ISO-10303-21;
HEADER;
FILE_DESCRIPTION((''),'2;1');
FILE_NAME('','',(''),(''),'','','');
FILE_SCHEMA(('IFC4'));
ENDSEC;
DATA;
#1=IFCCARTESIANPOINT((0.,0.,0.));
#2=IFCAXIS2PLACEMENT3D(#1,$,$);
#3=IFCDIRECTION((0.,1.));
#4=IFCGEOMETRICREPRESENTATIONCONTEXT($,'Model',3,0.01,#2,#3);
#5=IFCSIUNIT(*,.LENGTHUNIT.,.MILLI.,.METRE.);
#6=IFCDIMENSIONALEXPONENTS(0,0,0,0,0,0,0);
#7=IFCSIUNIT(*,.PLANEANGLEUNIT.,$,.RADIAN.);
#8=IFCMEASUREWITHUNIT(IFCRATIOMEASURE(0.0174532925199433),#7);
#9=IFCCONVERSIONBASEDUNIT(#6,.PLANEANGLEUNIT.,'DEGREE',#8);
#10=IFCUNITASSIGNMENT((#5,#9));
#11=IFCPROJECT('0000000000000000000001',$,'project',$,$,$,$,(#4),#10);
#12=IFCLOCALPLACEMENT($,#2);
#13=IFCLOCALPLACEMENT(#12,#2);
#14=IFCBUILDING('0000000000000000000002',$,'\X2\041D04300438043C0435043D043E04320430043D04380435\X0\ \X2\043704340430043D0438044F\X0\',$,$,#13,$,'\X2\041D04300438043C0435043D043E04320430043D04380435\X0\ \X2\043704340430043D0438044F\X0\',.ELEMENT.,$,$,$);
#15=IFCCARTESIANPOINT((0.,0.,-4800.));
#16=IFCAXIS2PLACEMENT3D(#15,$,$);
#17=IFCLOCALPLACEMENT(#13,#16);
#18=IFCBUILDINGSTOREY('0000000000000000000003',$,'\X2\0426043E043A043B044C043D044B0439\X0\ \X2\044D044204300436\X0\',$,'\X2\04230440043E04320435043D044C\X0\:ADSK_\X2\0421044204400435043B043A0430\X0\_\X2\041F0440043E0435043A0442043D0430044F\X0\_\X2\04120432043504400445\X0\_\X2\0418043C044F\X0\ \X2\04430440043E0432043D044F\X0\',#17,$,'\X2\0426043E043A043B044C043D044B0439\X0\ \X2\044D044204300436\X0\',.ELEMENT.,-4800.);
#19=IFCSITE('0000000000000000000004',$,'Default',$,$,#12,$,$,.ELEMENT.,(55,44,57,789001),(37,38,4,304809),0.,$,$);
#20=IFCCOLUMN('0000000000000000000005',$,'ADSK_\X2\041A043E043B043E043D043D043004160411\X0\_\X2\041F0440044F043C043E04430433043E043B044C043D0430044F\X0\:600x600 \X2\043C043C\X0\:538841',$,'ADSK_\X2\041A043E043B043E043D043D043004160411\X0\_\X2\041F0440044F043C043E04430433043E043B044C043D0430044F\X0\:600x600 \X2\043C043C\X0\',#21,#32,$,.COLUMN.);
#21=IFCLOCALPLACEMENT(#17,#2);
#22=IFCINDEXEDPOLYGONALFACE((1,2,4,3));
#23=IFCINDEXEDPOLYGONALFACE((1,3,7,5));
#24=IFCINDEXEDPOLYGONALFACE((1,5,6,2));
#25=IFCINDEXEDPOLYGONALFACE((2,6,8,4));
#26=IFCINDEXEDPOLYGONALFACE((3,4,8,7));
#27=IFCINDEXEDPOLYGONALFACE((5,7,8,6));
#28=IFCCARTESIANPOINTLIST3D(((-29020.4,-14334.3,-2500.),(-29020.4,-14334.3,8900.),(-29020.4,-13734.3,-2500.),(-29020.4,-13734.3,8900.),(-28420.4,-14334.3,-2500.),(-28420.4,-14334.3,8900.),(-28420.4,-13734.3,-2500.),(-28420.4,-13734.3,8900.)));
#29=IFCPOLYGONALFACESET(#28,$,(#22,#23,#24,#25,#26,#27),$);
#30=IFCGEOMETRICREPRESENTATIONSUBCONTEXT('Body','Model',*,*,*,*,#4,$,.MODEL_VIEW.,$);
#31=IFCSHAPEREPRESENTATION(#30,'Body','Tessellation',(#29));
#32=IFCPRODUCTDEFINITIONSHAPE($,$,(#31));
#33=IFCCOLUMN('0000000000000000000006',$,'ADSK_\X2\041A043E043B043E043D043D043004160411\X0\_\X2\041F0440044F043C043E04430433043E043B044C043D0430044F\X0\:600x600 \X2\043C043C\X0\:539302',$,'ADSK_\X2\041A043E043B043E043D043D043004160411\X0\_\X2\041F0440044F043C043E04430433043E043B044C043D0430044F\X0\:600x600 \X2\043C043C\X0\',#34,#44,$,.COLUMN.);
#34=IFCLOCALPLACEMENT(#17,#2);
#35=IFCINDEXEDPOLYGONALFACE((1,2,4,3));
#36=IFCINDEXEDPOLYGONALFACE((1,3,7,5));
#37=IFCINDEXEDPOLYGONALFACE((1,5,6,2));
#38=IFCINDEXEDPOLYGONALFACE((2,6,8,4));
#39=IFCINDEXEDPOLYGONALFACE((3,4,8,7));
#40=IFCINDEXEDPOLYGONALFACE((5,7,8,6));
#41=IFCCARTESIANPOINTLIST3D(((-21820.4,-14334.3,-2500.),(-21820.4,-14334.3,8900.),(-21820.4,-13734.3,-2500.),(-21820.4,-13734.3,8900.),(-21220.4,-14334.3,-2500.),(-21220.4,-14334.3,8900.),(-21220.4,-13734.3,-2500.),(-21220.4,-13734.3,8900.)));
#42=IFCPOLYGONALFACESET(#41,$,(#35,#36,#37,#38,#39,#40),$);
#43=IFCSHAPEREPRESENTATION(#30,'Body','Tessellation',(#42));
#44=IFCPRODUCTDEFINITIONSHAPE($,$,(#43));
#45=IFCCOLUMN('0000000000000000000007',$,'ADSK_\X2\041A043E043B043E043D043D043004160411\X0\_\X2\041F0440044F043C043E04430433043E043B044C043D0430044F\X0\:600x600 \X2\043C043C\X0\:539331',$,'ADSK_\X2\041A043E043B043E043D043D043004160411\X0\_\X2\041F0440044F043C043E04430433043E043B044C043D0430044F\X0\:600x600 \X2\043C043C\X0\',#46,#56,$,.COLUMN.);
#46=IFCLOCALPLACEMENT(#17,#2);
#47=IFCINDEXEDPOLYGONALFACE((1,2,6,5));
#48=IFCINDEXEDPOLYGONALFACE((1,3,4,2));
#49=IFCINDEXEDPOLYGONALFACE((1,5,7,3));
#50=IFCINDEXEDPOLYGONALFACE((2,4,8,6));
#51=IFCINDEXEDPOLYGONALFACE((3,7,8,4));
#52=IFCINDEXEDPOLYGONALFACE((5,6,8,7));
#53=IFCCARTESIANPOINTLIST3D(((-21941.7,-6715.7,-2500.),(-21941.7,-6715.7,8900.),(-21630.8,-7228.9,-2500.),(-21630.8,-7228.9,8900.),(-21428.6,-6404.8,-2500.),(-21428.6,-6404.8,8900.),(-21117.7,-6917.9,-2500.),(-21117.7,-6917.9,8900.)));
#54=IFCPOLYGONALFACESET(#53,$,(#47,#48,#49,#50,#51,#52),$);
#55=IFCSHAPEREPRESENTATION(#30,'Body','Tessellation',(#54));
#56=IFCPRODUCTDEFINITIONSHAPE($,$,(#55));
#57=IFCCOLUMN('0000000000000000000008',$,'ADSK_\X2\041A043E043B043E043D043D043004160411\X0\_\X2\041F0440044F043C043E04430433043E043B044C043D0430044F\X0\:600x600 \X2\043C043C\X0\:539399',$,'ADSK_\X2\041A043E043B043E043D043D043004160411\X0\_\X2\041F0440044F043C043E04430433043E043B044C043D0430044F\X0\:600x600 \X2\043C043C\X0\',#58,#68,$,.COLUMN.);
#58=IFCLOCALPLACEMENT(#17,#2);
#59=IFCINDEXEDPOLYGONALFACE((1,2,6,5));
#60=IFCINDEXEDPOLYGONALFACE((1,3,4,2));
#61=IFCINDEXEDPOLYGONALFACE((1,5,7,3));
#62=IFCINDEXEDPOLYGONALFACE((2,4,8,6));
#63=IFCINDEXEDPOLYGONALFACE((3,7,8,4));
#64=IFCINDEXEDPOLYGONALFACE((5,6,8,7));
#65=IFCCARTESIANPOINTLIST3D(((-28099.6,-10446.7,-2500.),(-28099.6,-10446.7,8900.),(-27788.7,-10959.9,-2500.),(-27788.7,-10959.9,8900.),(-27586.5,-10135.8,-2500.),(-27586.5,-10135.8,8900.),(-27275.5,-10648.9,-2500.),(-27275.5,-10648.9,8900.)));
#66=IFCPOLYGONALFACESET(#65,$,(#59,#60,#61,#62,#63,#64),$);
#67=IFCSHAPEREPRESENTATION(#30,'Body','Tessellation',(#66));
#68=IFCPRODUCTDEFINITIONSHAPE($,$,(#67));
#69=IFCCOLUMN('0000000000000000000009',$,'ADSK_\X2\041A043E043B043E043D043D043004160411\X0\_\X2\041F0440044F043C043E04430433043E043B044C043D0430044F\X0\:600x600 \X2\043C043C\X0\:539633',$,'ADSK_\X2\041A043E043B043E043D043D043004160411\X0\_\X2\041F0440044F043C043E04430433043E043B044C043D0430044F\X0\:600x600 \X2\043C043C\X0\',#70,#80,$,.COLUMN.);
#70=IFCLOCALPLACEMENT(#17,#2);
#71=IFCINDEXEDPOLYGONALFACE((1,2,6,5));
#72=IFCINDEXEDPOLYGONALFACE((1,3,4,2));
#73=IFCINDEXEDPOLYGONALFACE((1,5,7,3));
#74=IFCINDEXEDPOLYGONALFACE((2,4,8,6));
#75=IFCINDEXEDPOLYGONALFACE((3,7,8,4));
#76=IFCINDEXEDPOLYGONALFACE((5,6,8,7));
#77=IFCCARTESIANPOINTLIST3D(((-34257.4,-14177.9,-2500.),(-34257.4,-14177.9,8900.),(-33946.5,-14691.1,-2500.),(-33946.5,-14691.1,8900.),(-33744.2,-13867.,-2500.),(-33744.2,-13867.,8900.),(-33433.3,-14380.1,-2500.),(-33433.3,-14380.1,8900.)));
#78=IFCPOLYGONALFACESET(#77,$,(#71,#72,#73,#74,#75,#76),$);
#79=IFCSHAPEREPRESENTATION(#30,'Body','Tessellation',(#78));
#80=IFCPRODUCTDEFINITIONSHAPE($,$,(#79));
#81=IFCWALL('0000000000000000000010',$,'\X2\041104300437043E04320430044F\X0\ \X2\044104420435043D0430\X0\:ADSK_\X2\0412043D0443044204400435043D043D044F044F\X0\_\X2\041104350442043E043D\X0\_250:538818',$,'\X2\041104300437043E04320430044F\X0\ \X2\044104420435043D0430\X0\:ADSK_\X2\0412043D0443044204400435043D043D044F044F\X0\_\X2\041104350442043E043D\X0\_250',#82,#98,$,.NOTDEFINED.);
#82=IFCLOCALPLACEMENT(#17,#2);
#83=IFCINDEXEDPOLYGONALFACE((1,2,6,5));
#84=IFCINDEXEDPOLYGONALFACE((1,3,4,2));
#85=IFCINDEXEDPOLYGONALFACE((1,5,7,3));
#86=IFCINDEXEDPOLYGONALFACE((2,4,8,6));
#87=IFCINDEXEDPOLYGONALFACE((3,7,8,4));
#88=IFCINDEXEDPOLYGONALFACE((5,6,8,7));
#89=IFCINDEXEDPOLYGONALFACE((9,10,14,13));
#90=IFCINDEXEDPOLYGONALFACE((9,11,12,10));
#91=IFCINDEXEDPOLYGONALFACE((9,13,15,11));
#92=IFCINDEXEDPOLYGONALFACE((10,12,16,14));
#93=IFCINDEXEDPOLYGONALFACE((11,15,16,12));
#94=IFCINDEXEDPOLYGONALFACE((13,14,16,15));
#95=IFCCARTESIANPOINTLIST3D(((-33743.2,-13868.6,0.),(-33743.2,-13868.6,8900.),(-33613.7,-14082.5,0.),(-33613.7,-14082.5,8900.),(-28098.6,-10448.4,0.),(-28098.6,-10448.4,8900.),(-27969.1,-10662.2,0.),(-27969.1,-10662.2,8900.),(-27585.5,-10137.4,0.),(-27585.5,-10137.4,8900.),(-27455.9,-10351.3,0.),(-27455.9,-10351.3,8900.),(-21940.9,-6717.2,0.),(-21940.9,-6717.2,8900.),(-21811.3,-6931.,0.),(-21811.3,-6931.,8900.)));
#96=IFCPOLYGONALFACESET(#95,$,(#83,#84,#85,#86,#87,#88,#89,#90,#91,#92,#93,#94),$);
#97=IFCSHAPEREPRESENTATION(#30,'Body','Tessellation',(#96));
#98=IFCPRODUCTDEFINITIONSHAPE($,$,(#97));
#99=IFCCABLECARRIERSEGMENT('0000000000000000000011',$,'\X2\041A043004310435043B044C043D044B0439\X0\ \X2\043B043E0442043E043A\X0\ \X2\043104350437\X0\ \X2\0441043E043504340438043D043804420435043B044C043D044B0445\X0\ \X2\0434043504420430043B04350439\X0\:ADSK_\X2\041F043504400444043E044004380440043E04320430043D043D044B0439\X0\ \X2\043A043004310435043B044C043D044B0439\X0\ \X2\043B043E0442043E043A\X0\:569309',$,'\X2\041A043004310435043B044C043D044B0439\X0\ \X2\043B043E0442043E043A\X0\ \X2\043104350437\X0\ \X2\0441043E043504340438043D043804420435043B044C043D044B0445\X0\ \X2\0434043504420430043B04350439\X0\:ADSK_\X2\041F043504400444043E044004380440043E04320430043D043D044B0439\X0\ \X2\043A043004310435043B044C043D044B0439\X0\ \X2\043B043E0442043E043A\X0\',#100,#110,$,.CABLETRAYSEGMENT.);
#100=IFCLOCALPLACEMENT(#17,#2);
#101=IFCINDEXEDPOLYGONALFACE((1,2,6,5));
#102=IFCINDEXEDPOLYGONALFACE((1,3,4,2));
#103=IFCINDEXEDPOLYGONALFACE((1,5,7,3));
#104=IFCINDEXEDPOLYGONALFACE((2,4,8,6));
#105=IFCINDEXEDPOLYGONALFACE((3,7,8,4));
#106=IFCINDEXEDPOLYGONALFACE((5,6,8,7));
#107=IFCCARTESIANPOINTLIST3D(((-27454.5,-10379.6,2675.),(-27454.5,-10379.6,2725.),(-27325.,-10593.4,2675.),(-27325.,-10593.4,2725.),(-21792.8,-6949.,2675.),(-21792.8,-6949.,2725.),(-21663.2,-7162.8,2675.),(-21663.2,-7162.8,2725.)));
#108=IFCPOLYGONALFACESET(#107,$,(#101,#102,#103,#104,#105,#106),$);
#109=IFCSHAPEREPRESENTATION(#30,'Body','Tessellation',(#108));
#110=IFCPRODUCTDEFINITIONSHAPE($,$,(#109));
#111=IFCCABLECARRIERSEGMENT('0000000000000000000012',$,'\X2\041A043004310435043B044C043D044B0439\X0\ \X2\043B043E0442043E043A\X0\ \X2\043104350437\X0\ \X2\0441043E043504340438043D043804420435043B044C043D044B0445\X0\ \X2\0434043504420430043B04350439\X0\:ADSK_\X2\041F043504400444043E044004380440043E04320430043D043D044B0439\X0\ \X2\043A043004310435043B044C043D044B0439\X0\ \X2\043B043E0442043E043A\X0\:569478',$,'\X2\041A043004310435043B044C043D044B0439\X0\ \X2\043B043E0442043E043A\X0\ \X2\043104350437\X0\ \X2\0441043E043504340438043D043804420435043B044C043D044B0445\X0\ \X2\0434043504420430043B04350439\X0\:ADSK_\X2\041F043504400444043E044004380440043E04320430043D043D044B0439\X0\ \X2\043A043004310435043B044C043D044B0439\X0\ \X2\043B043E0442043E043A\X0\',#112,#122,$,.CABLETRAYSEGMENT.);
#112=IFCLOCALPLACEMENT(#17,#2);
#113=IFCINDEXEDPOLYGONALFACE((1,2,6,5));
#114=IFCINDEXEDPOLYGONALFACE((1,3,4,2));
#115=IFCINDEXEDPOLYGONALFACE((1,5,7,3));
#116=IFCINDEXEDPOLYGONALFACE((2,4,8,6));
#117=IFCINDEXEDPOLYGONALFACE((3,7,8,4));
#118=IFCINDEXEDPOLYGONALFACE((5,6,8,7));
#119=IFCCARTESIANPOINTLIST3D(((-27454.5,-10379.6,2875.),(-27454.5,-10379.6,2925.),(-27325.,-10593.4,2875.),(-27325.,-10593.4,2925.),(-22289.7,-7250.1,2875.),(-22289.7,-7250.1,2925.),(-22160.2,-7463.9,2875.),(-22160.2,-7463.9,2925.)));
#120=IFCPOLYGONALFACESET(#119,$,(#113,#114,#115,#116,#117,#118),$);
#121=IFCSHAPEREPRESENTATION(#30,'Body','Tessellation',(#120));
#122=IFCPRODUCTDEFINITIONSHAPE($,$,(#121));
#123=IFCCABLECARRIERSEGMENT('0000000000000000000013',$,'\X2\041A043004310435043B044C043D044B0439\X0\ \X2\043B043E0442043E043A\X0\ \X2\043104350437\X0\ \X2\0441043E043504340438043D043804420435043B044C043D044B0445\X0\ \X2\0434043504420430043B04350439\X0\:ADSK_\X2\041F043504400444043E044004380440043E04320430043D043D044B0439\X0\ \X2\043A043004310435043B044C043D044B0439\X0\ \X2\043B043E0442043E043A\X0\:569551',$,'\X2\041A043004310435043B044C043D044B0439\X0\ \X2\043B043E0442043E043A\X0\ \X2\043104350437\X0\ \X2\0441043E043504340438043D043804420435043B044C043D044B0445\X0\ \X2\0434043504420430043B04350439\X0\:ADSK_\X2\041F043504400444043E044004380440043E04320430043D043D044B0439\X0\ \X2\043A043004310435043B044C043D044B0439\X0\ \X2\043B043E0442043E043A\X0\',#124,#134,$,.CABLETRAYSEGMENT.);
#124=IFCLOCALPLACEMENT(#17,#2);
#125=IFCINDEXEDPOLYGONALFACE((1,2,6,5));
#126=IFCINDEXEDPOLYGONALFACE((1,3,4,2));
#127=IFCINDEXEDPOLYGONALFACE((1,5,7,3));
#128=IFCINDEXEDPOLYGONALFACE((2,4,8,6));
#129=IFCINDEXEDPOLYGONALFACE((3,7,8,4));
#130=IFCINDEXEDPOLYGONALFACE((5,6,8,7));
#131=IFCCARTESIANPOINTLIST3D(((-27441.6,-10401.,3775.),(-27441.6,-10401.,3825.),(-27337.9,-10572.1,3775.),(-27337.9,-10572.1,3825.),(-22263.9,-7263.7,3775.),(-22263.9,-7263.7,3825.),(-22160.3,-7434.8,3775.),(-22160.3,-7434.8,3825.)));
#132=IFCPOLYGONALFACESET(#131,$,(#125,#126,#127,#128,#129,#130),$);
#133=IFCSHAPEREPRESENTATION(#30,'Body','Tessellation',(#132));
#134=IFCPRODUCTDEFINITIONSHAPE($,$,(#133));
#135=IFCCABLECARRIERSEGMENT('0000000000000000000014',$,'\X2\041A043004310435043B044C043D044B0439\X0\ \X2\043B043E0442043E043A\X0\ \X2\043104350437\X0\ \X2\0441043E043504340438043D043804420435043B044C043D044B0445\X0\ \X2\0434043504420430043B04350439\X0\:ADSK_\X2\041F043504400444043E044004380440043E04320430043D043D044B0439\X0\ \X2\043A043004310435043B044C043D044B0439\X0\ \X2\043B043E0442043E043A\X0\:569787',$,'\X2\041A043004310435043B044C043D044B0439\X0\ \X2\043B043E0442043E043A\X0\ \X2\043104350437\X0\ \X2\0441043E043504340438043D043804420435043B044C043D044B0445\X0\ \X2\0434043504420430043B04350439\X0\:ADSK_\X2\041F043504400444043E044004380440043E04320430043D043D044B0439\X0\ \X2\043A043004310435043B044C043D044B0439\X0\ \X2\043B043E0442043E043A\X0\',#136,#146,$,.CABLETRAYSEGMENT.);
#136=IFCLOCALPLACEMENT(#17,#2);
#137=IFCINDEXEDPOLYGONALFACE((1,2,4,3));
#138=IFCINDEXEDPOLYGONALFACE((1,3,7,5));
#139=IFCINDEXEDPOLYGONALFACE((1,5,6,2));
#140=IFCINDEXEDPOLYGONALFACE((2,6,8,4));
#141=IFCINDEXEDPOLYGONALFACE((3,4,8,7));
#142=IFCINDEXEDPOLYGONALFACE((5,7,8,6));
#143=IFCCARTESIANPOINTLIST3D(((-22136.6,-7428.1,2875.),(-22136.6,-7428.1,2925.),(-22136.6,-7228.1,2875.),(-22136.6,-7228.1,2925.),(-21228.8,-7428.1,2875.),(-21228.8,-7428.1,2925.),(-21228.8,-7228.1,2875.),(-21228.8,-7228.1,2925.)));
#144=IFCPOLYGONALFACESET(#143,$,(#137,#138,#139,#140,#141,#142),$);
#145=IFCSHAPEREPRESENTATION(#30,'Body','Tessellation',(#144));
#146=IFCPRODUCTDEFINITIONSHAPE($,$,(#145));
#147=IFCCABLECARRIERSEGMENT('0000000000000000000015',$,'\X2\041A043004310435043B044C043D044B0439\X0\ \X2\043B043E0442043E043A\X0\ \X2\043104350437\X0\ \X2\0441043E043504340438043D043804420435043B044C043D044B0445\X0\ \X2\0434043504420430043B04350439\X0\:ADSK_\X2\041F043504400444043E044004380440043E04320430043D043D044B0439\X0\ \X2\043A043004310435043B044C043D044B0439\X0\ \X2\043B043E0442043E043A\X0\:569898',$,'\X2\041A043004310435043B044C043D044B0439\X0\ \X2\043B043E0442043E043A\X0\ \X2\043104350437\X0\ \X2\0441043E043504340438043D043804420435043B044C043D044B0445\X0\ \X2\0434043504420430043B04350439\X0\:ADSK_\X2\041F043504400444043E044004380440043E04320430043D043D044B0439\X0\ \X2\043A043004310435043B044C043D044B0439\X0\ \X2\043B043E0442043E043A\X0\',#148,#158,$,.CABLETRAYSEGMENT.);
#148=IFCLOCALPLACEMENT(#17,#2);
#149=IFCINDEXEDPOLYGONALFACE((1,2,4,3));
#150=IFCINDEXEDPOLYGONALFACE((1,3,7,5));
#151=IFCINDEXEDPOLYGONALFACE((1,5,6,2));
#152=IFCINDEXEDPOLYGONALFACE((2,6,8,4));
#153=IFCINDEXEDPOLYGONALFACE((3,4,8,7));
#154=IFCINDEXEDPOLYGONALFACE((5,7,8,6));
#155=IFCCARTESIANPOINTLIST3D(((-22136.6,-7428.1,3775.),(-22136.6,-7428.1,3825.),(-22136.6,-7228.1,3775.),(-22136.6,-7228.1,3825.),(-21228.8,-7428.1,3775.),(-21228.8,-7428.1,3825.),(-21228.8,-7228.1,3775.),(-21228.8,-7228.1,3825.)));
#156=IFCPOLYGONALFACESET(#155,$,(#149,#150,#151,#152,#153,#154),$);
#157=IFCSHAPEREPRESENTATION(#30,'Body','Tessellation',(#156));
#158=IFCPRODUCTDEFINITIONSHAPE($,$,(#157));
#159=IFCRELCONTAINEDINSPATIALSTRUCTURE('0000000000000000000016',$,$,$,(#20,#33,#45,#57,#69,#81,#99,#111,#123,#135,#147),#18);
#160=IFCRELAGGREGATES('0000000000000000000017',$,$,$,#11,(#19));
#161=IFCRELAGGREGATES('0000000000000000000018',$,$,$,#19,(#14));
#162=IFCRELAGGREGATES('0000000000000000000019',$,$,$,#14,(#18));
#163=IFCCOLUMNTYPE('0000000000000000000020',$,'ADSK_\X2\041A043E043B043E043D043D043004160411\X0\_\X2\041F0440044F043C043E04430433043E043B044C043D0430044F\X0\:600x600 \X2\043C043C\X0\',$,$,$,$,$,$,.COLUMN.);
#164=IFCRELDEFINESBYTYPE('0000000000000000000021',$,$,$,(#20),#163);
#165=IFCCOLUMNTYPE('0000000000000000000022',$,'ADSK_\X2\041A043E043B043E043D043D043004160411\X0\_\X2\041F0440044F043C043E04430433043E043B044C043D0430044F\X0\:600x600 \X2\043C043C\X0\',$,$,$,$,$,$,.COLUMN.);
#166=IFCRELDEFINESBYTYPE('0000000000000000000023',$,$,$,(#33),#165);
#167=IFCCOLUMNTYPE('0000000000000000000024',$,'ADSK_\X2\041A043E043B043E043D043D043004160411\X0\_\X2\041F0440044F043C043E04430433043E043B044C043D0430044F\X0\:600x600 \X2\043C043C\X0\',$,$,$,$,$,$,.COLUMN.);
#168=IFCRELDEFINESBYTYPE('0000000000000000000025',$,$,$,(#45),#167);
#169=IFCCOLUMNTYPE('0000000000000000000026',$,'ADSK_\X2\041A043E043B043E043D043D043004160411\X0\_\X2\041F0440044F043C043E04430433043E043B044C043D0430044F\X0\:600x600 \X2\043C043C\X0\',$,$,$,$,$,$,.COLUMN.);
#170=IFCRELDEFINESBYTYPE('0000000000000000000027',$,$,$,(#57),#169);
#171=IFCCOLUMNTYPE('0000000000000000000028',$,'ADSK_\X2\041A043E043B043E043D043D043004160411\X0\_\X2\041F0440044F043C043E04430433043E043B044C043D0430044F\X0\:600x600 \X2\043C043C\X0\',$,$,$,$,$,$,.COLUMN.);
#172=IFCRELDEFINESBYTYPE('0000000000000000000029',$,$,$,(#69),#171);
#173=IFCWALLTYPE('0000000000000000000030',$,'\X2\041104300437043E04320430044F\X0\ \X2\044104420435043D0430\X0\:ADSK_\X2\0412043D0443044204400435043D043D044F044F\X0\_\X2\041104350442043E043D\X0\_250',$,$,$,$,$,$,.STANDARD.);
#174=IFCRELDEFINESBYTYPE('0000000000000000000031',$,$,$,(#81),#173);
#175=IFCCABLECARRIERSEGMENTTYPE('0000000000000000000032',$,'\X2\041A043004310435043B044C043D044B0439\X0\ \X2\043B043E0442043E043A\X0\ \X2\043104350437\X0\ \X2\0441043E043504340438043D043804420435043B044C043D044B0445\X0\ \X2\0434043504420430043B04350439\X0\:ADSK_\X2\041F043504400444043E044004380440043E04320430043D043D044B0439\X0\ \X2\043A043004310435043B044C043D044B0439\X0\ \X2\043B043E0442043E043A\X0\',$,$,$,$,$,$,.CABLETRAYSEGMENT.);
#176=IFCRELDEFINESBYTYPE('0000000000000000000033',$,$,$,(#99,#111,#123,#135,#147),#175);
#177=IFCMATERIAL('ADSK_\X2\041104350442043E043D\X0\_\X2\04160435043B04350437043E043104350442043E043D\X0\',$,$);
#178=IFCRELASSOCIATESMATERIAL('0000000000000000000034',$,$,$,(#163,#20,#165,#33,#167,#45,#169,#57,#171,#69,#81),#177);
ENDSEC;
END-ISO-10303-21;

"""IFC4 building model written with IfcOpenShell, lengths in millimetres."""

from ifc_helpers import new_model, entity, si_unit, converted_unit, direction, frame, origin, place, context, subcontext, project, spatial, indexed_curve, outline, extrude, source, transform, mapped, material, type_object, type_shapes, element, save


model = new_model("IFC4")

# Units and contexts
model_context = context("Model", 3, precision=0.01, world=origin(), true_north=direction((0.0, 1.0)))
body_context = subcontext(model_context, "Body", "Model", "MODEL_VIEW")
ifc_project = project(units=[si_unit("LENGTHUNIT", "METRE", prefix="MILLI"), converted_unit("PLANEANGLEUNIT", "DEGREE", entity("IfcRatioMeasure", 0.0174532925199433), si_unit("PLANEANGLEUNIT", "RADIAN"), dimensions=[0, 0, 0, 0, 0, 0, 0])], contexts=[model_context])

# Site, building, storey
site_placement = place(None, origin())
site = spatial("IfcSite", under=ifc_project, at=site_placement, Name="Default", CompositionType="ELEMENT", RefLatitude=(55, 44, 57, 789001), RefLongitude=(37, 38, 4, 304809), RefElevation=0.0)
building_placement = place(site_placement, origin())
building = spatial("IfcBuilding", under=site, at=building_placement, Name="Наименование здания", LongName="Наименование здания", CompositionType="ELEMENT")
storey_placement = place(building_placement, frame((0.0, 0.0, -4800.0)))
storey = spatial("IfcBuildingStorey", under=building, at=storey_placement, Name="Цокльный этаж", ObjectType="Уровень:ADSK_Стрелка_Проектная_Вверх_Имя уровня", LongName="Цокльный этаж", CompositionType="ELEMENT", Elevation=-4800.0)

# Columns
ifc_material_1 = material(Name="ADSK_Бетон_Железобетон")
column_type_1 = type_object("IfcColumnType", Name="ADSK_КолоннаЖБ_Прямоугольная:600x600 мм", PredefinedType="COLUMN", material=ifc_material_1)
shared_shape_1 = source(origin(), body_context, "Body", "SweptSolid", [
    extrude(outline(indexed_curve([(-300.0, -300.0), (300.0, -300.0), (300.0, 300.0), (-300.0, 300.0), (-300.0, -300.0)], self_intersect=False)), frame((-28720.4, -14034.3, -7300.0), z_axis=(0.0, 0.0, 1.0), x_axis=(0.0, -1.0, 0.0)), (0.0, 0.0, 1.0), 11400.0),
])
type_shapes(column_type_1, [shared_shape_1])
column_1_placement = place(storey_placement, frame((0.0, 0.0, 4800.0)))
element("IfcColumn", 1, at=column_1_placement, inside=storey, type_object=column_type_1, material=ifc_material_1, Name="ADSK_КолоннаЖБ_Прямоугольная:600x600 мм:538841", ObjectType="ADSK_КолоннаЖБ_Прямоугольная:600x600 мм", PredefinedType="COLUMN", context=body_context, shape_type="MappedRepresentation", body=[
    mapped(shared_shape_1, transform((0.0, 0.0, 0.0), scale=1.0)),
])
column_type_2 = type_object("IfcColumnType", Name="ADSK_КолоннаЖБ_Прямоугольная:600x600 мм", PredefinedType="COLUMN", material=ifc_material_1)
shared_shape_2 = source(origin(), body_context, "Body", "SweptSolid", [
    extrude(outline(indexed_curve([(-300.0, -300.0), (300.0, -300.0), (300.0, 300.0), (-300.0, 300.0), (-300.0, -300.0)], self_intersect=False)), frame((0.0, 0.0, -7300.0), z_axis=(0.0, 0.0, 1.0), x_axis=(0.0, -1.0, 0.0)), (0.0, 0.0, 1.0), 11400.0),
])
type_shapes(column_type_2, [shared_shape_2])
column_2_placement = place(storey_placement, frame((-21520.4, -14034.3, 4800.0)))
element("IfcColumn", 2, at=column_2_placement, inside=storey, type_object=column_type_2, material=ifc_material_1, Name="ADSK_КолоннаЖБ_Прямоугольная:600x600 мм:539302", ObjectType="ADSK_КолоннаЖБ_Прямоугольная:600x600 мм", PredefinedType="COLUMN", context=body_context, shape_type="MappedRepresentation", body=[
    mapped(shared_shape_2, transform((0.0, 0.0, 0.0), scale=1.0)),
])
column_type_3 = type_object("IfcColumnType", Name="ADSK_КолоннаЖБ_Прямоугольная:600x600 мм", PredefinedType="COLUMN", material=ifc_material_1)
shared_shape_3 = source(origin(), body_context, "Body", "SweptSolid", [
    extrude(outline(indexed_curve([(-300.0, -300.0), (300.0, -300.0), (300.0, 300.0), (-300.0, 300.0), (-300.0, -300.0)], self_intersect=False)), frame((-21529.7, -6816.8, -7300.0), z_axis=(0.0, 0.0, 1.0), x_axis=(-0.518223, 0.855246, 0.0)), (0.0, 0.0, 1.0), 11400.0),
])
type_shapes(column_type_3, [shared_shape_3])
column_3_placement = place(storey_placement, frame((0.0, 0.0, 4800.0)))
element("IfcColumn", 3, at=column_3_placement, inside=storey, type_object=column_type_3, material=ifc_material_1, Name="ADSK_КолоннаЖБ_Прямоугольная:600x600 мм:539331", ObjectType="ADSK_КолоннаЖБ_Прямоугольная:600x600 мм", PredefinedType="COLUMN", context=body_context, shape_type="MappedRepresentation", body=[
    mapped(shared_shape_3, transform((0.0, 0.0, 0.0), scale=1.0)),
])
column_type_4 = type_object("IfcColumnType", Name="ADSK_КолоннаЖБ_Прямоугольная:600x600 мм", PredefinedType="COLUMN", material=ifc_material_1)
shared_shape_4 = source(origin(), body_context, "Body", "SweptSolid", [
    extrude(outline(indexed_curve([(-300.0, -300.0), (300.0, -300.0), (300.0, 300.0), (-300.0, 300.0), (-300.0, -300.0)], self_intersect=False)), frame((-27687.6, -10547.8, -7300.0), z_axis=(0.0, 0.0, 1.0), x_axis=(-0.518223, 0.855246, 0.0)), (0.0, 0.0, 1.0), 11400.0),
])
type_shapes(column_type_4, [shared_shape_4])
column_4_placement = place(storey_placement, frame((0.0, 0.0, 4800.0)))
element("IfcColumn", 4, at=column_4_placement, inside=storey, type_object=column_type_4, material=ifc_material_1, Name="ADSK_КолоннаЖБ_Прямоугольная:600x600 мм:539399", ObjectType="ADSK_КолоннаЖБ_Прямоугольная:600x600 мм", PredefinedType="COLUMN", context=body_context, shape_type="MappedRepresentation", body=[
    mapped(shared_shape_4, transform((0.0, 0.0, 0.0), scale=1.0)),
])
column_type_5 = type_object("IfcColumnType", Name="ADSK_КолоннаЖБ_Прямоугольная:600x600 мм", PredefinedType="COLUMN", material=ifc_material_1)
shared_shape_5 = source(origin(), body_context, "Body", "SweptSolid", [
    extrude(outline(indexed_curve([(-300.0, -300.0), (300.0, -300.0), (300.0, 300.0), (-300.0, 300.0), (-300.0, -300.0)], self_intersect=False)), frame((-33845.4, -14279.0, -7300.0), z_axis=(0.0, 0.0, 1.0), x_axis=(-0.518223, 0.855246, 0.0)), (0.0, 0.0, 1.0), 11400.0),
])
type_shapes(column_type_5, [shared_shape_5])
column_5_placement = place(storey_placement, frame((0.0, 0.0, 4800.0)))
element("IfcColumn", 5, at=column_5_placement, inside=storey, type_object=column_type_5, material=ifc_material_1, Name="ADSK_КолоннаЖБ_Прямоугольная:600x600 мм:539633", ObjectType="ADSK_КолоннаЖБ_Прямоугольная:600x600 мм", PredefinedType="COLUMN", context=body_context, shape_type="MappedRepresentation", body=[
    mapped(shared_shape_5, transform((0.0, 0.0, 0.0), scale=1.0)),
])

# Wall, opening
wall_type = type_object("IfcWallType", Name="Базовая стена:ADSK_Внутренняя_Бетон_250", PredefinedType="STANDARD")
wall_placement = place(storey_placement, frame((-33678.5, -13975.5, 0.0), z_axis=(0.0, 0.0, 1.0), x_axis=(0.855246, 0.518223, 0.0)))
wall = element("IfcWall", 6, at=wall_placement, inside=storey, type_object=wall_type, material=ifc_material_1, Name="Базовая стена:ADSK_Внутренняя_Бетон_250:538818", ObjectType="Базовая стена:ADSK_Внутренняя_Бетон_250", PredefinedType="NOTDEFINED", context=body_context, shape_type="SweptSolid", body=[
    extrude(outline(indexed_curve([(13800.0, 125.0), (0.0, 125.0), (0.0, -125.0), (13800.0, -125.0), (13800.0, 125.0)], self_intersect=False)), origin(), (0.0, 0.0, 1.0), 8900.0),
])
opening_placement = place(storey_placement, frame((-33678.5, -13975.5, 0.0), z_axis=(0.0, 0.0, 1.0), x_axis=(0.855246, 0.518223, 0.0)))
element("IfcOpeningElement", 7, at=opening_placement, cuts=wall, PredefinedType="OPENING", context=body_context, shape_type="SweptSolid", body=[
    extrude(outline(indexed_curve([(-4450.0, -125.0), (4450.0, -125.0), (4450.0, 125.0), (-4450.0, 125.0), (-4450.0, -125.0)], self_intersect=False)), frame((6600.0, 0.0, 4450.0), z_axis=(1.0, 0.0, 0.0), x_axis=(0.0, 0.0, -1.0)), (0.0, 0.0, 1.0), 600.0),
])

# Cable carrier segments
cable_carrier_segment_type = type_object("IfcCableCarrierSegmentType", Name="Кабельный лоток без соединительных деталей:ADSK_Перфорированный кабельный лоток", PredefinedType="CABLETRAYSEGMENT")
cable_carrier_segment_1_placement = place(storey_placement, origin())
element("IfcCableCarrierSegment", 8, at=cable_carrier_segment_1_placement, inside=storey, type_object=cable_carrier_segment_type, Name="Кабельный лоток без соединительных деталей:ADSK_Перфорированный кабельный лоток:569309", ObjectType="Кабельный лоток без соединительных деталей:ADSK_Перфорированный кабельный лоток", PredefinedType="CABLETRAYSEGMENT", context=body_context, shape_type="SweptSolid", body=[
    extrude(outline(indexed_curve([(-3310.0, -125.0), (3310.0, -125.0), (3310.0, 125.0), (-3310.0, 125.0), (-3310.0, -125.0)], self_intersect=False)), frame((-24558.9, -8771.2, 2675.0), z_axis=(0.0, 0.0, 1.0), x_axis=(-0.855246, -0.518223, 0.0)), (0.0, 0.0, 1.0), 50.0),
])
cable_carrier_segment_2_placement = place(storey_placement, origin())
element("IfcCableCarrierSegment", 9, at=cable_carrier_segment_2_placement, inside=storey, type_object=cable_carrier_segment_type, Name="Кабельный лоток без соединительных деталей:ADSK_Перфорированный кабельный лоток:569478", ObjectType="Кабельный лоток без соединительных деталей:ADSK_Перфорированный кабельный лоток", PredefinedType="CABLETRAYSEGMENT", context=body_context, shape_type="SweptSolid", body=[
    extrude(outline(indexed_curve([(-3019.5, -125.0), (3019.5, -125.0), (3019.5, 125.0), (-3019.5, 125.0), (-3019.5, -125.0)], self_intersect=False)), frame((-24807.3, -8921.8, 2875.0), z_axis=(0.0, 0.0, 1.0), x_axis=(-0.855246, -0.518223, 0.0)), (0.0, 0.0, 1.0), 50.0),
])
cable_carrier_segment_3_placement = place(storey_placement, origin())
element("IfcCableCarrierSegment", 10, at=cable_carrier_segment_3_placement, inside=storey, type_object=cable_carrier_segment_type, Name="Кабельный лоток без соединительных деталей:ADSK_Перфорированный кабельный лоток:569551", ObjectType="Кабельный лоток без соединительных деталей:ADSK_Перфорированный кабельный лоток", PredefinedType="CABLETRAYSEGMENT", context=body_context, shape_type="SweptSolid", body=[
    extrude(outline(indexed_curve([(-3027.0, -100.0), (3027.0, -100.0), (3027.0, 100.0), (-3027.0, 100.0), (-3027.0, -100.0)], self_intersect=False)), frame((-24800.9, -8917.9, 3775.0), z_axis=(0.0, 0.0, 1.0), x_axis=(-0.855246, -0.518223, 0.0)), (0.0, 0.0, 1.0), 50.0),
])
cable_carrier_segment_4_placement = place(storey_placement, origin())
element("IfcCableCarrierSegment", 11, at=cable_carrier_segment_4_placement, inside=storey, type_object=cable_carrier_segment_type, Name="Кабельный лоток без соединительных деталей:ADSK_Перфорированный кабельный лоток:569787", ObjectType="Кабельный лоток без соединительных деталей:ADSK_Перфорированный кабельный лоток", PredefinedType="CABLETRAYSEGMENT", context=body_context, shape_type="SweptSolid", body=[
    extrude(outline(indexed_curve([(-453.9, -100.0), (453.9, -100.0), (453.9, 100.0), (-453.9, 100.0), (-453.9, -100.0)], self_intersect=False)), frame((-21682.7, -7328.1, 2875.0)), (0.0, 0.0, 1.0), 50.0),
])
cable_carrier_segment_5_placement = place(storey_placement, origin())
element("IfcCableCarrierSegment", 12, at=cable_carrier_segment_5_placement, inside=storey, type_object=cable_carrier_segment_type, Name="Кабельный лоток без соединительных деталей:ADSK_Перфорированный кабельный лоток:569898", ObjectType="Кабельный лоток без соединительных деталей:ADSK_Перфорированный кабельный лоток", PredefinedType="CABLETRAYSEGMENT", context=body_context, shape_type="SweptSolid", body=[
    extrude(outline(indexed_curve([(-453.9, -100.0), (453.9, -100.0), (453.9, 100.0), (-453.9, 100.0), (-453.9, -100.0)], self_intersect=False)), frame((-21682.7, -7328.1, 3775.0)), (0.0, 0.0, 1.0), 50.0),
])

save(model, "model.ifc")
